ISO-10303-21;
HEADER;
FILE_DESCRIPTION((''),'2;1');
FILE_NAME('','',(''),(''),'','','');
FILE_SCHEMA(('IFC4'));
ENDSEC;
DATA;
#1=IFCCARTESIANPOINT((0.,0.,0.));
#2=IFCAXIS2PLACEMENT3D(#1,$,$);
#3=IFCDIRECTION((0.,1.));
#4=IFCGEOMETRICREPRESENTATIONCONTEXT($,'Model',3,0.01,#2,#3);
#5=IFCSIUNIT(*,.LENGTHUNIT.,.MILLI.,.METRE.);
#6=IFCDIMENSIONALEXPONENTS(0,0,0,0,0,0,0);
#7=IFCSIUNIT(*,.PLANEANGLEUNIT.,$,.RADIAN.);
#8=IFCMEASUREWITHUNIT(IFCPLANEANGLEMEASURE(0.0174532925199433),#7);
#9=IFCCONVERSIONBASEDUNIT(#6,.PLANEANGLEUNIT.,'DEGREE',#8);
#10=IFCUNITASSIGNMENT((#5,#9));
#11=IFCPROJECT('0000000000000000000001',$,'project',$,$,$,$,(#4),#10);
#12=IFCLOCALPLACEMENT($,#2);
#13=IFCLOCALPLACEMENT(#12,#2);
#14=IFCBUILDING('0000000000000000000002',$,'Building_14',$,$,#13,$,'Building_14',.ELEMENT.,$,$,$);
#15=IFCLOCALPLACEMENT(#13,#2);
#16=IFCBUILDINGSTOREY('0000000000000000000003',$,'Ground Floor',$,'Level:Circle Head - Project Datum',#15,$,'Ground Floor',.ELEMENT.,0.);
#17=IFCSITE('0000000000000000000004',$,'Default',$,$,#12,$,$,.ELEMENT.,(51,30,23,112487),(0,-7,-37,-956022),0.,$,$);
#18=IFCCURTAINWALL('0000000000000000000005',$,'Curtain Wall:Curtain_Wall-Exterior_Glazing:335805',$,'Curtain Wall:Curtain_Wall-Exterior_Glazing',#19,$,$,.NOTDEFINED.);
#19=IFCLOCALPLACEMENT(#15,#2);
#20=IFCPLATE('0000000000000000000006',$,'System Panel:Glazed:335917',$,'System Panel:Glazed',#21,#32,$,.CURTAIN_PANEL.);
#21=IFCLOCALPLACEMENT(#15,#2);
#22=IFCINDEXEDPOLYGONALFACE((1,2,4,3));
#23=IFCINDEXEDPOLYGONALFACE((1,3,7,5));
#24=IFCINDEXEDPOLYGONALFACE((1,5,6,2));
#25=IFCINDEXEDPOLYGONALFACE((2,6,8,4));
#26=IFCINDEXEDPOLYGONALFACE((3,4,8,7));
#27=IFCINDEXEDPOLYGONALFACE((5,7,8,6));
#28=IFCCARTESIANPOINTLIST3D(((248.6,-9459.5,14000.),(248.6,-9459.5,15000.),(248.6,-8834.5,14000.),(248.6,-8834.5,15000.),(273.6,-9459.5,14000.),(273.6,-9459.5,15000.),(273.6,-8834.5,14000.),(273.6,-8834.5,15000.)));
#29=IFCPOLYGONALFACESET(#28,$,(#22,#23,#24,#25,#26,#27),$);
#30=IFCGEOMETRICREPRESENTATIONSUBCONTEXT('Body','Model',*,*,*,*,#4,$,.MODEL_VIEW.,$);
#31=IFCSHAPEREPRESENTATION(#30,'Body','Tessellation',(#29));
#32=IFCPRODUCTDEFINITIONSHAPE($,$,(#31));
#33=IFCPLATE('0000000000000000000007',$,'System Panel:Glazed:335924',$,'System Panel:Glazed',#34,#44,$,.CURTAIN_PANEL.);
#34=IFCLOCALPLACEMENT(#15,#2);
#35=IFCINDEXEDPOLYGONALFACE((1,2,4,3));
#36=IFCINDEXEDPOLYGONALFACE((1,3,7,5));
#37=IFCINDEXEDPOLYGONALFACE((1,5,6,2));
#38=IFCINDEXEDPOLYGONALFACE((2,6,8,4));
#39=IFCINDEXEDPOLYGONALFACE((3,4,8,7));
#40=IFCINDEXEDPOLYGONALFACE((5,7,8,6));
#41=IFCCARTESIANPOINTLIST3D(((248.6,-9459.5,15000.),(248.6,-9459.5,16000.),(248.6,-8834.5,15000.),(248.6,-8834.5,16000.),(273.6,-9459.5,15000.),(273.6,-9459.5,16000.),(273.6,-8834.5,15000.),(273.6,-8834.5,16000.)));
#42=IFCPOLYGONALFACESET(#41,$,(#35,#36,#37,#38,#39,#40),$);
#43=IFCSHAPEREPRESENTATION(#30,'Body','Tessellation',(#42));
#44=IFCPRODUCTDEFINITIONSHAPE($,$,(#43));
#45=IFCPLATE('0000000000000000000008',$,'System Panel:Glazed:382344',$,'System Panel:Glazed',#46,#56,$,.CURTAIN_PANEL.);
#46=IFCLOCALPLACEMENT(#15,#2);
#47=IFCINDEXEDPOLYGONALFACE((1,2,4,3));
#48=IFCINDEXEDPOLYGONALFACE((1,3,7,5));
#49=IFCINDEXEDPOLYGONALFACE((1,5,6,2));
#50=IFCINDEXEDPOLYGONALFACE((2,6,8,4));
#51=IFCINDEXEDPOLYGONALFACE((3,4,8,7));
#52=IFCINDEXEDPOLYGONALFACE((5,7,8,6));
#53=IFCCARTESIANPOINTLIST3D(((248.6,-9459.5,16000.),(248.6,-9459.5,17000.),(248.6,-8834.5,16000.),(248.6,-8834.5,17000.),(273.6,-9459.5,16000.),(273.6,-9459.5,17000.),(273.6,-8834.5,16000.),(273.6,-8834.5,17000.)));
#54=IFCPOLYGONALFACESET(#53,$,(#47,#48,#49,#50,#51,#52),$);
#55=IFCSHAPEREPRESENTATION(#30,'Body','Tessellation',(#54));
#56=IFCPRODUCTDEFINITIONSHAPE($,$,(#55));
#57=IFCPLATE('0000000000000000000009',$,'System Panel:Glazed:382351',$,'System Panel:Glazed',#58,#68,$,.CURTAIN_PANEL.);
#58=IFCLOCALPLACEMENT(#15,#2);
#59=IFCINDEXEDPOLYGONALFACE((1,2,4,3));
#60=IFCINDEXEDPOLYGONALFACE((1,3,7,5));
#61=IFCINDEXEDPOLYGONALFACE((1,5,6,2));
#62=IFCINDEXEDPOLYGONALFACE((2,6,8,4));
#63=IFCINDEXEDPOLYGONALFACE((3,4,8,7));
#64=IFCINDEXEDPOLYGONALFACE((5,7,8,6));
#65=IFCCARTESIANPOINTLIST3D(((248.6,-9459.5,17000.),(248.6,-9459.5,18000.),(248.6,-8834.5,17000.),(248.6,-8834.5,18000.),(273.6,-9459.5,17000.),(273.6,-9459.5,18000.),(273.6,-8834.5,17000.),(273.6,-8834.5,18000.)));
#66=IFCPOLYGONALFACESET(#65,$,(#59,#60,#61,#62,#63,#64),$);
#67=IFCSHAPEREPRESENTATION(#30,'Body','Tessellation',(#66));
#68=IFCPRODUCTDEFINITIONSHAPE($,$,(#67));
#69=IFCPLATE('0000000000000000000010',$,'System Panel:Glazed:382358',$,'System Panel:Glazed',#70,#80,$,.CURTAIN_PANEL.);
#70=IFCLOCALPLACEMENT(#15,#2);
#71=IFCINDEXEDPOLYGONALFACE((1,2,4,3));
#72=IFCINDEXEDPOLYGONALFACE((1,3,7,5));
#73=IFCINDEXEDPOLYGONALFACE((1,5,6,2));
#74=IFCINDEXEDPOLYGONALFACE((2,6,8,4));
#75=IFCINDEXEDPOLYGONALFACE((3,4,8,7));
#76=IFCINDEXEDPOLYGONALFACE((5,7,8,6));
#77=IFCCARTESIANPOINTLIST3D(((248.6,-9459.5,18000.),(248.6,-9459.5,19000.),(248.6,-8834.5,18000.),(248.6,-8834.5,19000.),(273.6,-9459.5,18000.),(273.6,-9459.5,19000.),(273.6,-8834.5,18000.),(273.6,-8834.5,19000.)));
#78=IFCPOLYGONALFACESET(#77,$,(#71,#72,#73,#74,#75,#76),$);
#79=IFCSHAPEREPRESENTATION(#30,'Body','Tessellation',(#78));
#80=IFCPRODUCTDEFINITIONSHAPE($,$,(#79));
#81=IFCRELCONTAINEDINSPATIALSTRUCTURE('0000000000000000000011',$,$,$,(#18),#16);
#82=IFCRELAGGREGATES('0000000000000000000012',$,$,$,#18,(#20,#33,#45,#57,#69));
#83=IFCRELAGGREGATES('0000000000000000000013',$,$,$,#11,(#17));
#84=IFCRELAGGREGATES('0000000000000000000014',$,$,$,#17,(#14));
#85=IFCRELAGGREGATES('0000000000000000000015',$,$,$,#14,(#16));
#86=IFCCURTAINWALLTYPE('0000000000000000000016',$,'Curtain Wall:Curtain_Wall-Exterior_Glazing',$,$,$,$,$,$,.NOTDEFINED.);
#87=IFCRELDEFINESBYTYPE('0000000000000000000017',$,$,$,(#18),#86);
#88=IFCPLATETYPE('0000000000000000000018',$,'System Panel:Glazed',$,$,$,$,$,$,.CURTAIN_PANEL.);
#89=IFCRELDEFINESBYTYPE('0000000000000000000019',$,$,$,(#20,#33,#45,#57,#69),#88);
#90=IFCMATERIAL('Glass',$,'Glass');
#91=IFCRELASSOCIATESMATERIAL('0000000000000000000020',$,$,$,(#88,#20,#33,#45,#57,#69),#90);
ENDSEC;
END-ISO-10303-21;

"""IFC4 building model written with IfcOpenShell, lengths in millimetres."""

from ifc_helpers import new_model, entity, si_unit, converted_unit, direction, frame, origin, place, context, subcontext, project, spatial, indexed_curve, outline, extrude, source, transform, mapped, material, type_object, type_shapes, element, aggregate, save


model = new_model("IFC4")

# Units and contexts
model_context = context("Model", 3, precision=0.01, world=origin(), true_north=direction((0.0, 1.0)))
body_context = subcontext(model_context, "Body", "Model", "MODEL_VIEW")
ifc_project = project(units=[si_unit("LENGTHUNIT", "METRE", prefix="MILLI"), converted_unit("PLANEANGLEUNIT", "DEGREE", entity("IfcPlaneAngleMeasure", 0.0174532925199433), si_unit("PLANEANGLEUNIT", "RADIAN"), dimensions=[0, 0, 0, 0, 0, 0, 0])], contexts=[model_context])

# Site, building, storey
site_placement = place(None, origin())
site = spatial("IfcSite", under=ifc_project, at=site_placement, Name="Default", CompositionType="ELEMENT", RefLatitude=(51, 30, 23, 112487), RefLongitude=(0, -7, -37, -956022), RefElevation=0.0)
building_placement = place(site_placement, origin())
building = spatial("IfcBuilding", under=site, at=building_placement, Name="Building_14", LongName="Building_14", CompositionType="ELEMENT")
storey_placement = place(building_placement, origin())
storey = spatial("IfcBuildingStorey", under=building, at=storey_placement, Name="Ground Floor", ObjectType="Level:Circle Head - Project Datum", LongName="Ground Floor", CompositionType="ELEMENT", Elevation=0.0)

# Shared definitions
curtain_wall_type = type_object("IfcCurtainWallType", Name="Curtain Wall:Curtain_Wall-Exterior_Glazing", PredefinedType="NOTDEFINED")
ifc_material = material(Name="Glass", Category="Glass")

# Curtain wall, plates
curtain_wall_1_placement = place(storey_placement, origin())
curtain_wall_1 = element("IfcCurtainWall", 1, at=curtain_wall_1_placement, inside=storey, type_object=curtain_wall_type, Name="Curtain Wall:Curtain_Wall-Exterior_Glazing:335805", ObjectType="Curtain Wall:Curtain_Wall-Exterior_Glazing", PredefinedType="NOTDEFINED")
plate_type_1 = type_object("IfcPlateType", Name="System Panel:Glazed", PredefinedType="CURTAIN_PANEL", material=ifc_material)
shared_shape_1 = source(origin(), body_context, "Body", "SweptSolid", [
    extrude(outline(indexed_curve([(-12.5, -312.5), (12.5, -312.5), (12.5, 312.5), (-12.5, 312.5), (-12.5, -312.5)], self_intersect=False)), frame((0.0, -37.0, 0.0), z_axis=(0.0, 0.0, 1.0), x_axis=(0.0, 1.0, 0.0)), (0.0, 0.0, 1.0), 1000.0),
])
type_shapes(plate_type_1, [shared_shape_1])
plate_1_placement = place(curtain_wall_1_placement, frame((298.1, -9147.0, 14000.0), z_axis=(0.0, 0.0, 1.0), x_axis=(0.0, -1.0, 0.0)))
plate_1 = element("IfcPlate", 2, at=plate_1_placement, type_object=plate_type_1, material=ifc_material, Name="System Panel:Glazed:335917", ObjectType="System Panel:Glazed", PredefinedType="CURTAIN_PANEL", context=body_context, shape_type="MappedRepresentation", body=[
    mapped(shared_shape_1, transform((0.0, 0.0, 0.0), scale=1.0)),
])
plate_2_placement = place(curtain_wall_1_placement, frame((298.1, -9147.0, 15000.0), z_axis=(0.0, 0.0, 1.0), x_axis=(0.0, -1.0, 0.0)))
plate_2 = element("IfcPlate", 3, at=plate_2_placement, type_object=plate_type_1, material=ifc_material, Name="System Panel:Glazed:335924", ObjectType="System Panel:Glazed", PredefinedType="CURTAIN_PANEL", context=body_context, shape_type="MappedRepresentation", body=[
    mapped(shared_shape_1, transform((0.0, 0.0, 0.0), scale=1.0)),
])
plate_3_placement = place(curtain_wall_1_placement, frame((298.1, -9147.0, 16000.0), z_axis=(0.0, 0.0, 1.0), x_axis=(0.0, -1.0, 0.0)))
plate_3 = element("IfcPlate", 4, at=plate_3_placement, type_object=plate_type_1, material=ifc_material, Name="System Panel:Glazed:382344", ObjectType="System Panel:Glazed", PredefinedType="CURTAIN_PANEL", context=body_context, shape_type="MappedRepresentation", body=[
    mapped(shared_shape_1, transform((0.0, 0.0, 0.0), scale=1.0)),
])
plate_4_placement = place(curtain_wall_1_placement, frame((298.1, -9147.0, 17000.0), z_axis=(0.0, 0.0, 1.0), x_axis=(0.0, -1.0, 0.0)))
plate_4 = element("IfcPlate", 5, at=plate_4_placement, type_object=plate_type_1, material=ifc_material, Name="System Panel:Glazed:382351", ObjectType="System Panel:Glazed", PredefinedType="CURTAIN_PANEL", context=body_context, shape_type="MappedRepresentation", body=[
    mapped(shared_shape_1, transform((0.0, 0.0, 0.0), scale=1.0)),
])
plate_5_placement = place(curtain_wall_1_placement, frame((298.1, -9147.0, 18000.0), z_axis=(0.0, 0.0, 1.0), x_axis=(0.0, -1.0, 0.0)))
plate_5 = element("IfcPlate", 6, at=plate_5_placement, type_object=plate_type_1, material=ifc_material, Name="System Panel:Glazed:382358", ObjectType="System Panel:Glazed", PredefinedType="CURTAIN_PANEL", context=body_context, shape_type="MappedRepresentation", body=[
    mapped(shared_shape_1, transform((0.0, 0.0, 0.0), scale=1.0)),
])
aggregate(curtain_wall_1, [plate_1, plate_2, plate_3, plate_4, plate_5])

save(model, "model.ifc")
